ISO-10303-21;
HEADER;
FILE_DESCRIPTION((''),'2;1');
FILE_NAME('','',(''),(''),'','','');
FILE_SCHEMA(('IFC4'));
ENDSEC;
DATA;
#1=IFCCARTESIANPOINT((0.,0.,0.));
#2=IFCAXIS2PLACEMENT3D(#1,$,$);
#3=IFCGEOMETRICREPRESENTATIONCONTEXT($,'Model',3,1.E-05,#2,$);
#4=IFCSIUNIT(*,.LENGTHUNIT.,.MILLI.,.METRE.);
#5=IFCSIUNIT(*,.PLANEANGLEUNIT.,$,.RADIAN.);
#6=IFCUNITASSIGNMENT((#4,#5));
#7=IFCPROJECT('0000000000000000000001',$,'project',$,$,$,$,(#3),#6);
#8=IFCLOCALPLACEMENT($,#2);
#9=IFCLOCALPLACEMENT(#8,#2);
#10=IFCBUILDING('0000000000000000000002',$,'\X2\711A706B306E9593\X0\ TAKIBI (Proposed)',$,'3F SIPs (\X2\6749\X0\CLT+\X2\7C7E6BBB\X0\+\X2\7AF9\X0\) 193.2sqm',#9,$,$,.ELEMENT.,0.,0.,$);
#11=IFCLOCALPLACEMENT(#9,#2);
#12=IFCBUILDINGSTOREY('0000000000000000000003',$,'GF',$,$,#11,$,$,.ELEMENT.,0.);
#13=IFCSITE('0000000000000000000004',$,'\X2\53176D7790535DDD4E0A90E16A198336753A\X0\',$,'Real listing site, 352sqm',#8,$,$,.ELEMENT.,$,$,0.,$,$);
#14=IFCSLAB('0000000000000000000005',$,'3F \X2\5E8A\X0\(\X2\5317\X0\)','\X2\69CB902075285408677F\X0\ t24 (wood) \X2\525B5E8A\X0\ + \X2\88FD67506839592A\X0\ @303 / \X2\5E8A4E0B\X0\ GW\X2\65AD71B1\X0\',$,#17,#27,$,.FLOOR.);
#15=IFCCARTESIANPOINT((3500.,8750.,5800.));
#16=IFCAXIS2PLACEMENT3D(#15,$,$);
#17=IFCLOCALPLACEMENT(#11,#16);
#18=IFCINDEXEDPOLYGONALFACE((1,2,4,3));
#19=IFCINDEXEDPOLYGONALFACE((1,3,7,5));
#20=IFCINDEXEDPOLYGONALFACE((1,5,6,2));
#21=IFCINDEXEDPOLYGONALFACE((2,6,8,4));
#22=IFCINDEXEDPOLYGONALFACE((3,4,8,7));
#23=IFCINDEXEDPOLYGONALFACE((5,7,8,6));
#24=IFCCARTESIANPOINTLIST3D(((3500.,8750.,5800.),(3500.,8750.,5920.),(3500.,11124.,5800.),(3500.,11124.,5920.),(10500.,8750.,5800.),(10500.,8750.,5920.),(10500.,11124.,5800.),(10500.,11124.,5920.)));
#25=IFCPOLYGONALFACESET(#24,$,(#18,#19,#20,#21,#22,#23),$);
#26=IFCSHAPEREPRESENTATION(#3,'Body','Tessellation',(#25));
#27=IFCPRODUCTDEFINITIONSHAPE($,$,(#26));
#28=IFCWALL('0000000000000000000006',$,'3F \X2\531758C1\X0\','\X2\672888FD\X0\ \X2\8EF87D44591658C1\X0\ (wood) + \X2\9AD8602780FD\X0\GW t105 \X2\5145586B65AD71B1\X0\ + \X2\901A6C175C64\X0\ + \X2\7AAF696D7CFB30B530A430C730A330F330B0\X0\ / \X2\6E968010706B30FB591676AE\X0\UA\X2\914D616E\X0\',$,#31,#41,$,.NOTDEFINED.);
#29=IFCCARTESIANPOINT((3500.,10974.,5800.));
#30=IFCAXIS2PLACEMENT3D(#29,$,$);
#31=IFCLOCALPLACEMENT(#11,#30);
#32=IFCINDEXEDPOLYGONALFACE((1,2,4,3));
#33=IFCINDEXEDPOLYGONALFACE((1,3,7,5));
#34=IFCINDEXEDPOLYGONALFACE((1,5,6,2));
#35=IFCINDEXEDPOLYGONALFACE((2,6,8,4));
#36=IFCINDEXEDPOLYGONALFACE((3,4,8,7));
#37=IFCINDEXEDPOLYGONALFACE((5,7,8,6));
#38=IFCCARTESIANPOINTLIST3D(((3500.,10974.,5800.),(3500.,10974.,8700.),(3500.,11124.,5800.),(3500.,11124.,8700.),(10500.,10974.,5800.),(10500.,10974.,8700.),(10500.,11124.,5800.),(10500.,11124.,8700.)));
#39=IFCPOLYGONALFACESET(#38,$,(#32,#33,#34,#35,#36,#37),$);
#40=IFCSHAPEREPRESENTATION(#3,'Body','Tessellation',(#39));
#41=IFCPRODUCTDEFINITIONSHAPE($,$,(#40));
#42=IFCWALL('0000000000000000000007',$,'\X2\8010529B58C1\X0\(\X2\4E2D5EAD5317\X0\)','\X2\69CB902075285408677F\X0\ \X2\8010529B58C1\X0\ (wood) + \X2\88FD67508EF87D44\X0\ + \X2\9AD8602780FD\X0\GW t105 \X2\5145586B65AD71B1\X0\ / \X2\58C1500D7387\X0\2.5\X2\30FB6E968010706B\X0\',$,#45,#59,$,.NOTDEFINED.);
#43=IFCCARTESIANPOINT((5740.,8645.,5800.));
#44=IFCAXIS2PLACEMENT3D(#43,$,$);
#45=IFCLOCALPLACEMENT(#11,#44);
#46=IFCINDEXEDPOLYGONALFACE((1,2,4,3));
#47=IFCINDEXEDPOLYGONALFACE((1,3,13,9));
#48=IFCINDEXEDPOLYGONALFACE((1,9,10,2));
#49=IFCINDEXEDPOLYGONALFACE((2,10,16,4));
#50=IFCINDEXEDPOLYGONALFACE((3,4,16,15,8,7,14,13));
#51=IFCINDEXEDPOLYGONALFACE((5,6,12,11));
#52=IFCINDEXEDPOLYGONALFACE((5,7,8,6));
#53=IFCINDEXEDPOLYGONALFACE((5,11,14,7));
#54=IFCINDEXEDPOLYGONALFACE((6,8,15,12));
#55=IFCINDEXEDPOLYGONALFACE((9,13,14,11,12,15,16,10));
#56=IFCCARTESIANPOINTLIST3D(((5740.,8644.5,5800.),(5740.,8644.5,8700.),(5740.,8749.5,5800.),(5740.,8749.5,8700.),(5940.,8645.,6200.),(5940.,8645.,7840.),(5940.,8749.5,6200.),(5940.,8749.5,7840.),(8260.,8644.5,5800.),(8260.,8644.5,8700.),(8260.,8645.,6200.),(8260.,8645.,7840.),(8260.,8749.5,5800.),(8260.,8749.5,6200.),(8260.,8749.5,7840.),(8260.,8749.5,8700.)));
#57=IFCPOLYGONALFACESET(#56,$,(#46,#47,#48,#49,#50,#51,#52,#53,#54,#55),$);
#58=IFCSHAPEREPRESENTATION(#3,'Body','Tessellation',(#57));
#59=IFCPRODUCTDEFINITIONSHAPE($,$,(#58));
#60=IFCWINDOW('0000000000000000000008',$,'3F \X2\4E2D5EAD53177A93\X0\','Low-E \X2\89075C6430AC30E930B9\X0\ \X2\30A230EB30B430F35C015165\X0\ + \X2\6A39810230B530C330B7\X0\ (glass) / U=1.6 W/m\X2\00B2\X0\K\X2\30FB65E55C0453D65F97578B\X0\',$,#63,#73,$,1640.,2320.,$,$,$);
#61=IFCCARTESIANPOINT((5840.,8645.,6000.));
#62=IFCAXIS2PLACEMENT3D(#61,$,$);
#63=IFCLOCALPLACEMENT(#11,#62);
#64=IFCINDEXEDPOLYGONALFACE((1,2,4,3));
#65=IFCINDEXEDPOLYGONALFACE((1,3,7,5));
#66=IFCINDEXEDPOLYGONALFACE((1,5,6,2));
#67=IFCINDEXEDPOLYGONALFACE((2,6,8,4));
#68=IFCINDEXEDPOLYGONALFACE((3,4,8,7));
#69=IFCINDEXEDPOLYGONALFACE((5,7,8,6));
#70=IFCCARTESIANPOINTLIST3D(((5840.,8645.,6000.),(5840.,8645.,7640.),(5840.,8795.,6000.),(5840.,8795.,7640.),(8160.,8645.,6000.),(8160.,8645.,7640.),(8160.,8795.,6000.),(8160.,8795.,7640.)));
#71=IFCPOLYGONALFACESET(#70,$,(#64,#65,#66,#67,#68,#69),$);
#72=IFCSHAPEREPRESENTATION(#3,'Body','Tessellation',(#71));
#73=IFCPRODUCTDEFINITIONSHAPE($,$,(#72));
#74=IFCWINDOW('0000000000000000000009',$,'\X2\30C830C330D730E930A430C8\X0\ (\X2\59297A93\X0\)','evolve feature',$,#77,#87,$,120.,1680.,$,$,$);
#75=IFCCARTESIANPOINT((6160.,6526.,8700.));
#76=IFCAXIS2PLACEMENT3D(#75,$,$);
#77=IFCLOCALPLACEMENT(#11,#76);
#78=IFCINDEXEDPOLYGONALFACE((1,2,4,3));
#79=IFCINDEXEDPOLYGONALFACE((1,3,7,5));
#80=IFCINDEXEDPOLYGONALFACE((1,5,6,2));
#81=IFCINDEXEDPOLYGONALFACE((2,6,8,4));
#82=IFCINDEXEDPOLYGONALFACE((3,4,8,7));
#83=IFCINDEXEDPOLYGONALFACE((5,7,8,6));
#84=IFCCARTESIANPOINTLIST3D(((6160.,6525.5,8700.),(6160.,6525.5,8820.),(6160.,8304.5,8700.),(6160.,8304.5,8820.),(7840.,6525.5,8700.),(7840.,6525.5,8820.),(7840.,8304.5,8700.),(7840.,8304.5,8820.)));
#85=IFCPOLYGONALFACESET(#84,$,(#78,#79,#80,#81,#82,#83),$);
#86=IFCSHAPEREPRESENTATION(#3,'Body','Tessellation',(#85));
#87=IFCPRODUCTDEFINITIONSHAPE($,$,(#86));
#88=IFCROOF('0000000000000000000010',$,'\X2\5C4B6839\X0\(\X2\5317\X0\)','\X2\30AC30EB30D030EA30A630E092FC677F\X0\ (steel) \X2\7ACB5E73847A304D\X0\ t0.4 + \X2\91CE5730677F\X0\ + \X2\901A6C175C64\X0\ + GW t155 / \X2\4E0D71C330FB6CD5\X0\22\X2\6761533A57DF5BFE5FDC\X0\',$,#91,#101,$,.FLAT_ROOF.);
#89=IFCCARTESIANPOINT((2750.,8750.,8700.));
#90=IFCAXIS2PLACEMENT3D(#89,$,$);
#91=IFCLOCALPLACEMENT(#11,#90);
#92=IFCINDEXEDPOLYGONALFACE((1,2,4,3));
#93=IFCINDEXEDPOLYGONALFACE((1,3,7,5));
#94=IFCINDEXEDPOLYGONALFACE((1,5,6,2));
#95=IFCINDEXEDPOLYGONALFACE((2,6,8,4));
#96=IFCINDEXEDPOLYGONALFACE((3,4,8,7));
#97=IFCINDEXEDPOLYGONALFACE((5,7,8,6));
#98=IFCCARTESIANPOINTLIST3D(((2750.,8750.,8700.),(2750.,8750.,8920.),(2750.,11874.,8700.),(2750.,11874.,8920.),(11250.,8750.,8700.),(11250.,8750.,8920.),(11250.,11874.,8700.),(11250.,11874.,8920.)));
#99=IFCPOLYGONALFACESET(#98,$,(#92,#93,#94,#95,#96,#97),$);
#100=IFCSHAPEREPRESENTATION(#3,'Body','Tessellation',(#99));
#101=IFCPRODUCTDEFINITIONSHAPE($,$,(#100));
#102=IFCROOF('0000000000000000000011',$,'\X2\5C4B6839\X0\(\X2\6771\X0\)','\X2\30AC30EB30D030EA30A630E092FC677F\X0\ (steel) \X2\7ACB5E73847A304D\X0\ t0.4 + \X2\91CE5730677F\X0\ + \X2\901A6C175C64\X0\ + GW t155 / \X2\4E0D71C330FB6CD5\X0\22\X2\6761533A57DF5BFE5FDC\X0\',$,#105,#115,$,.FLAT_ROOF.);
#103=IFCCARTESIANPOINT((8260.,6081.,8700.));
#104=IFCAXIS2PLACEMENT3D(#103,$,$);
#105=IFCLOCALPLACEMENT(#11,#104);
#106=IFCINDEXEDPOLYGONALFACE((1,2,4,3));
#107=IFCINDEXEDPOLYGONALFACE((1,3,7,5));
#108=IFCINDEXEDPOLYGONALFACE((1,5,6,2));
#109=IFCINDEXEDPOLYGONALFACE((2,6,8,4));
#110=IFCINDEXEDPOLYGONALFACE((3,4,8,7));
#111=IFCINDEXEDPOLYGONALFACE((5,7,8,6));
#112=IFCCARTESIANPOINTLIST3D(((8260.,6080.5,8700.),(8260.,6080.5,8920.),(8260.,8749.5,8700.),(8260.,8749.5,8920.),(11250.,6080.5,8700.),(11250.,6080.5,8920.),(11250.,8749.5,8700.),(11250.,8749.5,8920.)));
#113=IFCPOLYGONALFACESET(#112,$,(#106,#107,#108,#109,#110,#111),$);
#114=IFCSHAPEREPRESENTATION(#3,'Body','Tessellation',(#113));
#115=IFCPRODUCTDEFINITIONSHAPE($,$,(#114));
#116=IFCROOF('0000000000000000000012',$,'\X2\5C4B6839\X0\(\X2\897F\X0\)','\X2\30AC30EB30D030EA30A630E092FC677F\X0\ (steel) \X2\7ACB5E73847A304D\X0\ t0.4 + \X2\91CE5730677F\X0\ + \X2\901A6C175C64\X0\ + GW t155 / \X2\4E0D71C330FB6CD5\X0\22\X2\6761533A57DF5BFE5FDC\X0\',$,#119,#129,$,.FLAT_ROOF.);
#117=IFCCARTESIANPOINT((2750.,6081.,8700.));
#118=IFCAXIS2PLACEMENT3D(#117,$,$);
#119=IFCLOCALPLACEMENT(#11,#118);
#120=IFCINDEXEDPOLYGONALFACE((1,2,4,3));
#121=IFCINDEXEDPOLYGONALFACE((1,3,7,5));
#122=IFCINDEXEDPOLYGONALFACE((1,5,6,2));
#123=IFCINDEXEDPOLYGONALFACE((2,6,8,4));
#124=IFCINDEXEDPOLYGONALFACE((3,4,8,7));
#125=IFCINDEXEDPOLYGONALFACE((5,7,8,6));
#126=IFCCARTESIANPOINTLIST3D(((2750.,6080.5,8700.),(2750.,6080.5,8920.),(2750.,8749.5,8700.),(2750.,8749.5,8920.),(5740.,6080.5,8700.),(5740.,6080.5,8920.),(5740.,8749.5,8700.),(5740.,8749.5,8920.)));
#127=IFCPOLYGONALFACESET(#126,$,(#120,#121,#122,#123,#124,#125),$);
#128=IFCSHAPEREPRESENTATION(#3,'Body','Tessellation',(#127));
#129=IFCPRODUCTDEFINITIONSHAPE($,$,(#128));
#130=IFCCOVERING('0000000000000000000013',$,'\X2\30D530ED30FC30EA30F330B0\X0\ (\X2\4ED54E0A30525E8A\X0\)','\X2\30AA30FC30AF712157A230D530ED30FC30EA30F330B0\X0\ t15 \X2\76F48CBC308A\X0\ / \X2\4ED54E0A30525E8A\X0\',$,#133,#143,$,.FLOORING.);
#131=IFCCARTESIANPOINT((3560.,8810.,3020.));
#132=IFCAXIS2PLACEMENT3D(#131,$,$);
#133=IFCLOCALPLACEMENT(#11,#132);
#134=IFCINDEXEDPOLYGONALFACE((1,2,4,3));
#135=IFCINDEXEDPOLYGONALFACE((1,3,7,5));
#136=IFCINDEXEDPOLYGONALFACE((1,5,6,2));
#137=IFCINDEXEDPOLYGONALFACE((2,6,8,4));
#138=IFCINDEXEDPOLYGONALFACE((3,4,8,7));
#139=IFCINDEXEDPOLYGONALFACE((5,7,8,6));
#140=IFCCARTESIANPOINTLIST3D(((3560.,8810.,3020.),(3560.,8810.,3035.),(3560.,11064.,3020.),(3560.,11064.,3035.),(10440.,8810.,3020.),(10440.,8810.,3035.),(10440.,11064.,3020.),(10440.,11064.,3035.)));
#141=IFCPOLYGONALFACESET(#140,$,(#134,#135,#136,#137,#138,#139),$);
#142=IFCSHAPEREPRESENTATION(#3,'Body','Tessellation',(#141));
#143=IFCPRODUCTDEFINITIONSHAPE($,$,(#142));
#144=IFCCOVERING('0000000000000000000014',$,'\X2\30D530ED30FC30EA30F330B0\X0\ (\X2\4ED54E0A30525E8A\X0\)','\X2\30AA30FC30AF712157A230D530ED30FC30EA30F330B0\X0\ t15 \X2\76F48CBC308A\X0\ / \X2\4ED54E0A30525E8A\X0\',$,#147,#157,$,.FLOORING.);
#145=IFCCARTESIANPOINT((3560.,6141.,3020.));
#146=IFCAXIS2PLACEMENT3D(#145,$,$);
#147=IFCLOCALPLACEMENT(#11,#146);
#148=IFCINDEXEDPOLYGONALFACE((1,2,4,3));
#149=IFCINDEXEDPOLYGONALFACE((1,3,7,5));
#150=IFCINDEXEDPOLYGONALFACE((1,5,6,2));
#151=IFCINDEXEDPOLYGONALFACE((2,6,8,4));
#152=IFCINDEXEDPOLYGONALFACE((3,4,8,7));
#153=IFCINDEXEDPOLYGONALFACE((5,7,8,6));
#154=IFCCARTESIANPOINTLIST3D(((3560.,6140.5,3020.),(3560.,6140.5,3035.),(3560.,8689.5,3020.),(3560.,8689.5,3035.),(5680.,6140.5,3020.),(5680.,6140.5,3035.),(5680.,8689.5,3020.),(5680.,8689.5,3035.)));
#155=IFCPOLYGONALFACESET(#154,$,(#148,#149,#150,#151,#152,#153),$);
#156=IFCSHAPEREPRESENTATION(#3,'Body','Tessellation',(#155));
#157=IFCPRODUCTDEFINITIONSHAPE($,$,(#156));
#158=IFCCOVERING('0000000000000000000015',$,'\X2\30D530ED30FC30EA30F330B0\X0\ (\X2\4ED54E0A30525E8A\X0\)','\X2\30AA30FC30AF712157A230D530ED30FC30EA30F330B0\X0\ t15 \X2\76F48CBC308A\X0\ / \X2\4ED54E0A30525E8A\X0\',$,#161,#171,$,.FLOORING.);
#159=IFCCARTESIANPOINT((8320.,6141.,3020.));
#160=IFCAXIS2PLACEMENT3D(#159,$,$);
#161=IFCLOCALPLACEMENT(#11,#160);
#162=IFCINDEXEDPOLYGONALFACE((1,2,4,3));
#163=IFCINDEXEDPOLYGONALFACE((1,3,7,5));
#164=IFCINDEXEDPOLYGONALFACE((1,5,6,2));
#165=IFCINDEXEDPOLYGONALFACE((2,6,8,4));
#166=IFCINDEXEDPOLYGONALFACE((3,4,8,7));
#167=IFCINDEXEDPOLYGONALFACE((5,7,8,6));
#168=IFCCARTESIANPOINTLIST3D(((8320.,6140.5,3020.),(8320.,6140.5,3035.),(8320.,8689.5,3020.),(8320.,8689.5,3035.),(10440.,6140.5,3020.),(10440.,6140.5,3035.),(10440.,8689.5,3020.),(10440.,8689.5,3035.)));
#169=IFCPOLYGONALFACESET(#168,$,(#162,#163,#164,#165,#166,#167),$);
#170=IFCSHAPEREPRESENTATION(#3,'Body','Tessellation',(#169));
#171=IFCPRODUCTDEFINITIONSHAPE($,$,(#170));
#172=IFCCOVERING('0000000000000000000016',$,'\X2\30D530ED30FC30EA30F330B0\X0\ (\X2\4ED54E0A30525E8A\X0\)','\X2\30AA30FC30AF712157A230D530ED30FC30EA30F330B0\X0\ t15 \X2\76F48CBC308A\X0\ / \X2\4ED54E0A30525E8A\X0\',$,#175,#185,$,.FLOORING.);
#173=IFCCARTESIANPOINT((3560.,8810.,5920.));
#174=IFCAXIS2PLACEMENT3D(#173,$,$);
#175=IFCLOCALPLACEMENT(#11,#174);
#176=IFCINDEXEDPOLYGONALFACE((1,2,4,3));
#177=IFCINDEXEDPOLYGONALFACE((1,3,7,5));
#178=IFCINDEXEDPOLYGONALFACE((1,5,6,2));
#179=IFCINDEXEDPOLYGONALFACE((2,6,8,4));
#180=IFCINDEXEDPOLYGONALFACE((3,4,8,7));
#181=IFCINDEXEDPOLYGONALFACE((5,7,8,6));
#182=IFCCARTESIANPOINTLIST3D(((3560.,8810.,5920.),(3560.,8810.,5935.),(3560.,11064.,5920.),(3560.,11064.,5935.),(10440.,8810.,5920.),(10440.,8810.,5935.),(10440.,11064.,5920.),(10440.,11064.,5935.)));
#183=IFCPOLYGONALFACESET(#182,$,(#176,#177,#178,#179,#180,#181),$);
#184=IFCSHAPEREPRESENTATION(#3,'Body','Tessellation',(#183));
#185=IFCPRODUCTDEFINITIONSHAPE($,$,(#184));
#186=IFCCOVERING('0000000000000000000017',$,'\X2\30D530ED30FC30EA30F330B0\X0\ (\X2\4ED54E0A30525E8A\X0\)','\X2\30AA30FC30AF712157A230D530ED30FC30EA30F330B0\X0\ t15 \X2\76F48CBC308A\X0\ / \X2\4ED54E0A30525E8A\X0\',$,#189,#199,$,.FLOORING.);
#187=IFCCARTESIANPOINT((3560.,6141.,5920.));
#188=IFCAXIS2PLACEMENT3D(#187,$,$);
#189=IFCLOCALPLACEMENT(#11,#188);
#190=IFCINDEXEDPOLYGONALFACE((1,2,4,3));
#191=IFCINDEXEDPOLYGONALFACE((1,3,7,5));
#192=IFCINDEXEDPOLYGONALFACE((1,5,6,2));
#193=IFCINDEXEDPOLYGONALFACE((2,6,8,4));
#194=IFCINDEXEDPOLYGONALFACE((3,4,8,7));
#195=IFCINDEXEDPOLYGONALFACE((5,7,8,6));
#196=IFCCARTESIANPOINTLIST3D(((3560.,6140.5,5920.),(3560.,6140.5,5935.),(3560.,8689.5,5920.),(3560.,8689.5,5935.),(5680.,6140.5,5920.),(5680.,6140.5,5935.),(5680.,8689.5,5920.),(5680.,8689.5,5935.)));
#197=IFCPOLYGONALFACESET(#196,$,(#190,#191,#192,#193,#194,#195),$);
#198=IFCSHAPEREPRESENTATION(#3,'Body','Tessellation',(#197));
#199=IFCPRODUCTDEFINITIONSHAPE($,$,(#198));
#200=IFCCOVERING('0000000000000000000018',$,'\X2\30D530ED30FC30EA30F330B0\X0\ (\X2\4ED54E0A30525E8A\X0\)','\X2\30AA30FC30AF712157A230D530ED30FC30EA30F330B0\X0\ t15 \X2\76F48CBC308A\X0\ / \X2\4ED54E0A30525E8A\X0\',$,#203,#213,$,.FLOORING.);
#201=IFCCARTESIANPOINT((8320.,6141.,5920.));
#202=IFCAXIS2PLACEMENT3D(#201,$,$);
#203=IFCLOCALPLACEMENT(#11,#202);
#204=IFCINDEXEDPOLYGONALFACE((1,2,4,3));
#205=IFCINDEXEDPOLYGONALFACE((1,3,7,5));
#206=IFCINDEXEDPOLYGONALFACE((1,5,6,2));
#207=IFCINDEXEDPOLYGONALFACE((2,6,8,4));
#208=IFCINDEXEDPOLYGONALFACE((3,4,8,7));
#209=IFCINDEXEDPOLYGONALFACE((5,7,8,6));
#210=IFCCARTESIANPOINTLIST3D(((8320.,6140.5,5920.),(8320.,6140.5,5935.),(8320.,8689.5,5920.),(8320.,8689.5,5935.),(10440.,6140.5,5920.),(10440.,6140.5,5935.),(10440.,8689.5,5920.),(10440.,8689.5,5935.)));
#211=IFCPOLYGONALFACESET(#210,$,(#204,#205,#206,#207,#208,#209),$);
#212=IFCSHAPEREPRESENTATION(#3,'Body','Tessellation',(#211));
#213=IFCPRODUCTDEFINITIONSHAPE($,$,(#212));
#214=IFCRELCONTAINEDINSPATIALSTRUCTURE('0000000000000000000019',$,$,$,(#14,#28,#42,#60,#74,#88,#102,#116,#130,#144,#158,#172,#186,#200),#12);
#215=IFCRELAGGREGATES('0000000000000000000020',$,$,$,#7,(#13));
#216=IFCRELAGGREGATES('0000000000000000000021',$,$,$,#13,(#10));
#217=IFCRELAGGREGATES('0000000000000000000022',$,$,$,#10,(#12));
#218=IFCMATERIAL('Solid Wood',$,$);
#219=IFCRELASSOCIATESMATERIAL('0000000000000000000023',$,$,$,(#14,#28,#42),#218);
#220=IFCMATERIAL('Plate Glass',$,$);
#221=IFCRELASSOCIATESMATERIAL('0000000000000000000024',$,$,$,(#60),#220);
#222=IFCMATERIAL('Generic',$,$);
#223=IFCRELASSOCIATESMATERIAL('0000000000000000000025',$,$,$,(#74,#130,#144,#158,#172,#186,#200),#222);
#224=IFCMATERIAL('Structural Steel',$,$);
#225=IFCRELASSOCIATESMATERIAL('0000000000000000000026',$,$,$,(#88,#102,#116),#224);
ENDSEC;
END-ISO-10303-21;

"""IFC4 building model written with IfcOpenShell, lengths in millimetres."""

from ifc_helpers import new_model, si_unit, frame, frame_2d, origin, place, context, project, spatial, rectangle, extrude, material, element, fill, save


model = new_model("IFC4")

# Units and contexts
model_context = context("Model", 3, precision=1e-05, world=origin())
ifc_project = project(units=[si_unit("LENGTHUNIT", "METRE", prefix="MILLI"), si_unit("PLANEANGLEUNIT", "RADIAN")], contexts=[model_context])

# Site, building, storey
site_placement = place(None, origin())
site = spatial("IfcSite", under=ifc_project, at=site_placement, Name="北海道川上郡標茶町", ObjectType="Real listing site, 352sqm", CompositionType="ELEMENT", RefElevation=0.0)
building_placement = place(site_placement, origin())
building = spatial("IfcBuilding", under=site, at=building_placement, Name="焚火の間 TAKIBI (Proposed)", ObjectType="3F SIPs (杉CLT+籾殻+竹) 193.2sqm", CompositionType="ELEMENT", ElevationOfRefHeight=0.0, ElevationOfTerrain=0.0)
storey_placement = place(building_placement, origin())
storey = spatial("IfcBuildingStorey", under=building, at=storey_placement, Name="GF", CompositionType="ELEMENT", Elevation=0.0)

# Slab
ifc_material_1 = material(Name="Solid Wood")
slab_placement = place(storey_placement, frame((3500.0, 8750.0, 5800.0)))
element("IfcSlab", 1, at=slab_placement, inside=storey, material=ifc_material_1, Name="3F 床(北)", Description="構造用合板 t24 (wood) 剛床 + 製材根太 @303 / 床下 GW断熱", PredefinedType="FLOOR", context=model_context, shape_type="SweptSolid", body=[
    extrude(rectangle(XDim=7000.0, YDim=2374.0, at=frame_2d((3500.0, 1187.0))), frame((3500.0, 8750.0, 5800.0)), (0.0, 0.0, 1.0), 120.0),
])

# Wall
wall_1_placement = place(storey_placement, frame((3500.0, 10974.0, 5800.0)))
element("IfcWall", 2, at=wall_1_placement, inside=storey, material=ifc_material_1, Name="3F 北壁", Description="木製 軸組外壁 (wood) + 高性能GW t105 充填断熱 + 通気層 + 窯業系サイディング / 準耐火・外皮UA配慮", PredefinedType="NOTDEFINED", context=model_context, shape_type="SweptSolid", body=[
    extrude(rectangle(XDim=7000.0, YDim=150.0, at=frame_2d((3500.0, 75.0))), frame((3500.0, 10974.0, 5800.0)), (0.0, 0.0, 1.0), 2900.0),
])

# Wall, opening, window
wall_2_placement = place(storey_placement, frame((5740.0, 8645.0, 5800.0)))
wall_2 = element("IfcWall", 3, at=wall_2_placement, inside=storey, material=ifc_material_1, Name="耐力壁(中庭北)", Description="構造用合板 耐力壁 (wood) + 製材軸組 + 高性能GW t105 充填断熱 / 壁倍率2.5・準耐火", PredefinedType="NOTDEFINED", context=model_context, shape_type="SweptSolid", body=[
    extrude(rectangle(XDim=2520.0, YDim=105.0, at=frame_2d((1260.0, 52.0))), frame((5740.0, 8645.0, 5800.0)), (0.0, 0.0, 1.0), 2900.0),
])
opening_placement = place(storey_placement, frame((5840.0, 8645.0, 6000.0)))
opening = element("IfcOpeningElement", 4, at=opening_placement, cuts=wall_2, PredefinedType="NOTDEFINED", context=model_context, shape_type="SweptSolid", body=[
    extrude(rectangle(XDim=2320.0, YDim=150.0, at=frame_2d((1160.0, 75.0))), frame((5840.0, 8645.0, 6000.0)), (0.0, 0.0, 1.0), 1640.0),
])
ifc_material_2 = material(Name="Plate Glass")
window_1_placement = place(storey_placement, frame((5840.0, 8645.0, 6000.0)))
window_1 = element("IfcWindow", 5, at=window_1_placement, inside=storey, material=ifc_material_2, Name="3F 中庭北窓", Description="Low-E 複層ガラス アルゴン封入 + 樹脂サッシ (glass) / U=1.6 W/m²K・日射取得型", OverallHeight=1640.0, OverallWidth=2320.0, context=model_context, shape_type="SweptSolid", body=[
    extrude(rectangle(XDim=2320.0, YDim=150.0, at=frame_2d((1160.0, 75.0))), frame((5840.0, 8645.0, 6000.0)), (0.0, 0.0, 1.0), 1640.0),
])
fill(opening, window_1)

# Window
ifc_material_3 = material(Name="Generic")
window_2_placement = place(storey_placement, frame((6160.0, 6526.0, 8700.0)))
element("IfcWindow", 6, at=window_2_placement, inside=storey, material=ifc_material_3, Name="トップライト (天窓)", Description="evolve feature", OverallHeight=120.0, OverallWidth=1680.0, context=model_context, shape_type="SweptSolid", body=[
    extrude(rectangle(XDim=1680.0, YDim=1779.0, at=frame_2d((840.0, 889.0))), frame((6160.0, 6526.0, 8700.0)), (0.0, 0.0, 1.0), 120.0),
])

# Roofs
ifc_material_4 = material(Name="Structural Steel")
roof_1_placement = place(storey_placement, frame((2750.0, 8750.0, 8700.0)))
element("IfcRoof", 7, at=roof_1_placement, inside=storey, material=ifc_material_4, Name="屋根(北)", Description="ガルバリウム鋼板 (steel) 立平葺き t0.4 + 野地板 + 通気層 + GW t155 / 不燃・法22条区域対応", PredefinedType="FLAT_ROOF", context=model_context, shape_type="SweptSolid", body=[
    extrude(rectangle(XDim=8500.0, YDim=3124.0, at=frame_2d((4250.0, 1562.0))), frame((2750.0, 8750.0, 8700.0)), (0.0, 0.0, 1.0), 220.0),
])
roof_2_placement = place(storey_placement, frame((8260.0, 6081.0, 8700.0)))
element("IfcRoof", 8, at=roof_2_placement, inside=storey, material=ifc_material_4, Name="屋根(東)", Description="ガルバリウム鋼板 (steel) 立平葺き t0.4 + 野地板 + 通気層 + GW t155 / 不燃・法22条区域対応", PredefinedType="FLAT_ROOF", context=model_context, shape_type="SweptSolid", body=[
    extrude(rectangle(XDim=2990.0, YDim=2669.0, at=frame_2d((1495.0, 1334.0))), frame((8260.0, 6081.0, 8700.0)), (0.0, 0.0, 1.0), 220.0),
])
roof_3_placement = place(storey_placement, frame((2750.0, 6081.0, 8700.0)))
element("IfcRoof", 9, at=roof_3_placement, inside=storey, material=ifc_material_4, Name="屋根(西)", Description="ガルバリウム鋼板 (steel) 立平葺き t0.4 + 野地板 + 通気層 + GW t155 / 不燃・法22条区域対応", PredefinedType="FLAT_ROOF", context=model_context, shape_type="SweptSolid", body=[
    extrude(rectangle(XDim=2990.0, YDim=2669.0, at=frame_2d((1495.0, 1334.0))), frame((2750.0, 6081.0, 8700.0)), (0.0, 0.0, 1.0), 220.0),
])

# Coverings
covering_1_placement = place(storey_placement, frame((3560.0, 8810.0, 3020.0)))
element("IfcCovering", 10, at=covering_1_placement, inside=storey, material=ifc_material_3, Name="フローリング (仕上げ床)", Description="オーク無垢フローリング t15 直貼り / 仕上げ床", PredefinedType="FLOORING", context=model_context, shape_type="SweptSolid", body=[
    extrude(rectangle(XDim=6880.0, YDim=2254.0, at=frame_2d((3440.0, 1127.0))), frame((3560.0, 8810.0, 3020.0)), (0.0, 0.0, 1.0), 15.0),
])
covering_2_placement = place(storey_placement, frame((3560.0, 6141.0, 3020.0)))
element("IfcCovering", 11, at=covering_2_placement, inside=storey, material=ifc_material_3, Name="フローリング (仕上げ床)", Description="オーク無垢フローリング t15 直貼り / 仕上げ床", PredefinedType="FLOORING", context=model_context, shape_type="SweptSolid", body=[
    extrude(rectangle(XDim=2120.0, YDim=2549.0, at=frame_2d((1060.0, 1274.0))), frame((3560.0, 6141.0, 3020.0)), (0.0, 0.0, 1.0), 15.0),
])
covering_3_placement = place(storey_placement, frame((8320.0, 6141.0, 3020.0)))
element("IfcCovering", 12, at=covering_3_placement, inside=storey, material=ifc_material_3, Name="フローリング (仕上げ床)", Description="オーク無垢フローリング t15 直貼り / 仕上げ床", PredefinedType="FLOORING", context=model_context, shape_type="SweptSolid", body=[
    extrude(rectangle(XDim=2120.0, YDim=2549.0, at=frame_2d((1060.0, 1274.0))), frame((8320.0, 6141.0, 3020.0)), (0.0, 0.0, 1.0), 15.0),
])
covering_4_placement = place(storey_placement, frame((3560.0, 8810.0, 5920.0)))
element("IfcCovering", 13, at=covering_4_placement, inside=storey, material=ifc_material_3, Name="フローリング (仕上げ床)", Description="オーク無垢フローリング t15 直貼り / 仕上げ床", PredefinedType="FLOORING", context=model_context, shape_type="SweptSolid", body=[
    extrude(rectangle(XDim=6880.0, YDim=2254.0, at=frame_2d((3440.0, 1127.0))), frame((3560.0, 8810.0, 5920.0)), (0.0, 0.0, 1.0), 15.0),
])
covering_5_placement = place(storey_placement, frame((3560.0, 6141.0, 5920.0)))
element("IfcCovering", 14, at=covering_5_placement, inside=storey, material=ifc_material_3, Name="フローリング (仕上げ床)", Description="オーク無垢フローリング t15 直貼り / 仕上げ床", PredefinedType="FLOORING", context=model_context, shape_type="SweptSolid", body=[
    extrude(rectangle(XDim=2120.0, YDim=2549.0, at=frame_2d((1060.0, 1274.0))), frame((3560.0, 6141.0, 5920.0)), (0.0, 0.0, 1.0), 15.0),
])
covering_6_placement = place(storey_placement, frame((8320.0, 6141.0, 5920.0)))
element("IfcCovering", 15, at=covering_6_placement, inside=storey, material=ifc_material_3, Name="フローリング (仕上げ床)", Description="オーク無垢フローリング t15 直貼り / 仕上げ床", PredefinedType="FLOORING", context=model_context, shape_type="SweptSolid", body=[
    extrude(rectangle(XDim=2120.0, YDim=2549.0, at=frame_2d((1060.0, 1274.0))), frame((8320.0, 6141.0, 5920.0)), (0.0, 0.0, 1.0), 15.0),
])

save(model, "model.ifc")
